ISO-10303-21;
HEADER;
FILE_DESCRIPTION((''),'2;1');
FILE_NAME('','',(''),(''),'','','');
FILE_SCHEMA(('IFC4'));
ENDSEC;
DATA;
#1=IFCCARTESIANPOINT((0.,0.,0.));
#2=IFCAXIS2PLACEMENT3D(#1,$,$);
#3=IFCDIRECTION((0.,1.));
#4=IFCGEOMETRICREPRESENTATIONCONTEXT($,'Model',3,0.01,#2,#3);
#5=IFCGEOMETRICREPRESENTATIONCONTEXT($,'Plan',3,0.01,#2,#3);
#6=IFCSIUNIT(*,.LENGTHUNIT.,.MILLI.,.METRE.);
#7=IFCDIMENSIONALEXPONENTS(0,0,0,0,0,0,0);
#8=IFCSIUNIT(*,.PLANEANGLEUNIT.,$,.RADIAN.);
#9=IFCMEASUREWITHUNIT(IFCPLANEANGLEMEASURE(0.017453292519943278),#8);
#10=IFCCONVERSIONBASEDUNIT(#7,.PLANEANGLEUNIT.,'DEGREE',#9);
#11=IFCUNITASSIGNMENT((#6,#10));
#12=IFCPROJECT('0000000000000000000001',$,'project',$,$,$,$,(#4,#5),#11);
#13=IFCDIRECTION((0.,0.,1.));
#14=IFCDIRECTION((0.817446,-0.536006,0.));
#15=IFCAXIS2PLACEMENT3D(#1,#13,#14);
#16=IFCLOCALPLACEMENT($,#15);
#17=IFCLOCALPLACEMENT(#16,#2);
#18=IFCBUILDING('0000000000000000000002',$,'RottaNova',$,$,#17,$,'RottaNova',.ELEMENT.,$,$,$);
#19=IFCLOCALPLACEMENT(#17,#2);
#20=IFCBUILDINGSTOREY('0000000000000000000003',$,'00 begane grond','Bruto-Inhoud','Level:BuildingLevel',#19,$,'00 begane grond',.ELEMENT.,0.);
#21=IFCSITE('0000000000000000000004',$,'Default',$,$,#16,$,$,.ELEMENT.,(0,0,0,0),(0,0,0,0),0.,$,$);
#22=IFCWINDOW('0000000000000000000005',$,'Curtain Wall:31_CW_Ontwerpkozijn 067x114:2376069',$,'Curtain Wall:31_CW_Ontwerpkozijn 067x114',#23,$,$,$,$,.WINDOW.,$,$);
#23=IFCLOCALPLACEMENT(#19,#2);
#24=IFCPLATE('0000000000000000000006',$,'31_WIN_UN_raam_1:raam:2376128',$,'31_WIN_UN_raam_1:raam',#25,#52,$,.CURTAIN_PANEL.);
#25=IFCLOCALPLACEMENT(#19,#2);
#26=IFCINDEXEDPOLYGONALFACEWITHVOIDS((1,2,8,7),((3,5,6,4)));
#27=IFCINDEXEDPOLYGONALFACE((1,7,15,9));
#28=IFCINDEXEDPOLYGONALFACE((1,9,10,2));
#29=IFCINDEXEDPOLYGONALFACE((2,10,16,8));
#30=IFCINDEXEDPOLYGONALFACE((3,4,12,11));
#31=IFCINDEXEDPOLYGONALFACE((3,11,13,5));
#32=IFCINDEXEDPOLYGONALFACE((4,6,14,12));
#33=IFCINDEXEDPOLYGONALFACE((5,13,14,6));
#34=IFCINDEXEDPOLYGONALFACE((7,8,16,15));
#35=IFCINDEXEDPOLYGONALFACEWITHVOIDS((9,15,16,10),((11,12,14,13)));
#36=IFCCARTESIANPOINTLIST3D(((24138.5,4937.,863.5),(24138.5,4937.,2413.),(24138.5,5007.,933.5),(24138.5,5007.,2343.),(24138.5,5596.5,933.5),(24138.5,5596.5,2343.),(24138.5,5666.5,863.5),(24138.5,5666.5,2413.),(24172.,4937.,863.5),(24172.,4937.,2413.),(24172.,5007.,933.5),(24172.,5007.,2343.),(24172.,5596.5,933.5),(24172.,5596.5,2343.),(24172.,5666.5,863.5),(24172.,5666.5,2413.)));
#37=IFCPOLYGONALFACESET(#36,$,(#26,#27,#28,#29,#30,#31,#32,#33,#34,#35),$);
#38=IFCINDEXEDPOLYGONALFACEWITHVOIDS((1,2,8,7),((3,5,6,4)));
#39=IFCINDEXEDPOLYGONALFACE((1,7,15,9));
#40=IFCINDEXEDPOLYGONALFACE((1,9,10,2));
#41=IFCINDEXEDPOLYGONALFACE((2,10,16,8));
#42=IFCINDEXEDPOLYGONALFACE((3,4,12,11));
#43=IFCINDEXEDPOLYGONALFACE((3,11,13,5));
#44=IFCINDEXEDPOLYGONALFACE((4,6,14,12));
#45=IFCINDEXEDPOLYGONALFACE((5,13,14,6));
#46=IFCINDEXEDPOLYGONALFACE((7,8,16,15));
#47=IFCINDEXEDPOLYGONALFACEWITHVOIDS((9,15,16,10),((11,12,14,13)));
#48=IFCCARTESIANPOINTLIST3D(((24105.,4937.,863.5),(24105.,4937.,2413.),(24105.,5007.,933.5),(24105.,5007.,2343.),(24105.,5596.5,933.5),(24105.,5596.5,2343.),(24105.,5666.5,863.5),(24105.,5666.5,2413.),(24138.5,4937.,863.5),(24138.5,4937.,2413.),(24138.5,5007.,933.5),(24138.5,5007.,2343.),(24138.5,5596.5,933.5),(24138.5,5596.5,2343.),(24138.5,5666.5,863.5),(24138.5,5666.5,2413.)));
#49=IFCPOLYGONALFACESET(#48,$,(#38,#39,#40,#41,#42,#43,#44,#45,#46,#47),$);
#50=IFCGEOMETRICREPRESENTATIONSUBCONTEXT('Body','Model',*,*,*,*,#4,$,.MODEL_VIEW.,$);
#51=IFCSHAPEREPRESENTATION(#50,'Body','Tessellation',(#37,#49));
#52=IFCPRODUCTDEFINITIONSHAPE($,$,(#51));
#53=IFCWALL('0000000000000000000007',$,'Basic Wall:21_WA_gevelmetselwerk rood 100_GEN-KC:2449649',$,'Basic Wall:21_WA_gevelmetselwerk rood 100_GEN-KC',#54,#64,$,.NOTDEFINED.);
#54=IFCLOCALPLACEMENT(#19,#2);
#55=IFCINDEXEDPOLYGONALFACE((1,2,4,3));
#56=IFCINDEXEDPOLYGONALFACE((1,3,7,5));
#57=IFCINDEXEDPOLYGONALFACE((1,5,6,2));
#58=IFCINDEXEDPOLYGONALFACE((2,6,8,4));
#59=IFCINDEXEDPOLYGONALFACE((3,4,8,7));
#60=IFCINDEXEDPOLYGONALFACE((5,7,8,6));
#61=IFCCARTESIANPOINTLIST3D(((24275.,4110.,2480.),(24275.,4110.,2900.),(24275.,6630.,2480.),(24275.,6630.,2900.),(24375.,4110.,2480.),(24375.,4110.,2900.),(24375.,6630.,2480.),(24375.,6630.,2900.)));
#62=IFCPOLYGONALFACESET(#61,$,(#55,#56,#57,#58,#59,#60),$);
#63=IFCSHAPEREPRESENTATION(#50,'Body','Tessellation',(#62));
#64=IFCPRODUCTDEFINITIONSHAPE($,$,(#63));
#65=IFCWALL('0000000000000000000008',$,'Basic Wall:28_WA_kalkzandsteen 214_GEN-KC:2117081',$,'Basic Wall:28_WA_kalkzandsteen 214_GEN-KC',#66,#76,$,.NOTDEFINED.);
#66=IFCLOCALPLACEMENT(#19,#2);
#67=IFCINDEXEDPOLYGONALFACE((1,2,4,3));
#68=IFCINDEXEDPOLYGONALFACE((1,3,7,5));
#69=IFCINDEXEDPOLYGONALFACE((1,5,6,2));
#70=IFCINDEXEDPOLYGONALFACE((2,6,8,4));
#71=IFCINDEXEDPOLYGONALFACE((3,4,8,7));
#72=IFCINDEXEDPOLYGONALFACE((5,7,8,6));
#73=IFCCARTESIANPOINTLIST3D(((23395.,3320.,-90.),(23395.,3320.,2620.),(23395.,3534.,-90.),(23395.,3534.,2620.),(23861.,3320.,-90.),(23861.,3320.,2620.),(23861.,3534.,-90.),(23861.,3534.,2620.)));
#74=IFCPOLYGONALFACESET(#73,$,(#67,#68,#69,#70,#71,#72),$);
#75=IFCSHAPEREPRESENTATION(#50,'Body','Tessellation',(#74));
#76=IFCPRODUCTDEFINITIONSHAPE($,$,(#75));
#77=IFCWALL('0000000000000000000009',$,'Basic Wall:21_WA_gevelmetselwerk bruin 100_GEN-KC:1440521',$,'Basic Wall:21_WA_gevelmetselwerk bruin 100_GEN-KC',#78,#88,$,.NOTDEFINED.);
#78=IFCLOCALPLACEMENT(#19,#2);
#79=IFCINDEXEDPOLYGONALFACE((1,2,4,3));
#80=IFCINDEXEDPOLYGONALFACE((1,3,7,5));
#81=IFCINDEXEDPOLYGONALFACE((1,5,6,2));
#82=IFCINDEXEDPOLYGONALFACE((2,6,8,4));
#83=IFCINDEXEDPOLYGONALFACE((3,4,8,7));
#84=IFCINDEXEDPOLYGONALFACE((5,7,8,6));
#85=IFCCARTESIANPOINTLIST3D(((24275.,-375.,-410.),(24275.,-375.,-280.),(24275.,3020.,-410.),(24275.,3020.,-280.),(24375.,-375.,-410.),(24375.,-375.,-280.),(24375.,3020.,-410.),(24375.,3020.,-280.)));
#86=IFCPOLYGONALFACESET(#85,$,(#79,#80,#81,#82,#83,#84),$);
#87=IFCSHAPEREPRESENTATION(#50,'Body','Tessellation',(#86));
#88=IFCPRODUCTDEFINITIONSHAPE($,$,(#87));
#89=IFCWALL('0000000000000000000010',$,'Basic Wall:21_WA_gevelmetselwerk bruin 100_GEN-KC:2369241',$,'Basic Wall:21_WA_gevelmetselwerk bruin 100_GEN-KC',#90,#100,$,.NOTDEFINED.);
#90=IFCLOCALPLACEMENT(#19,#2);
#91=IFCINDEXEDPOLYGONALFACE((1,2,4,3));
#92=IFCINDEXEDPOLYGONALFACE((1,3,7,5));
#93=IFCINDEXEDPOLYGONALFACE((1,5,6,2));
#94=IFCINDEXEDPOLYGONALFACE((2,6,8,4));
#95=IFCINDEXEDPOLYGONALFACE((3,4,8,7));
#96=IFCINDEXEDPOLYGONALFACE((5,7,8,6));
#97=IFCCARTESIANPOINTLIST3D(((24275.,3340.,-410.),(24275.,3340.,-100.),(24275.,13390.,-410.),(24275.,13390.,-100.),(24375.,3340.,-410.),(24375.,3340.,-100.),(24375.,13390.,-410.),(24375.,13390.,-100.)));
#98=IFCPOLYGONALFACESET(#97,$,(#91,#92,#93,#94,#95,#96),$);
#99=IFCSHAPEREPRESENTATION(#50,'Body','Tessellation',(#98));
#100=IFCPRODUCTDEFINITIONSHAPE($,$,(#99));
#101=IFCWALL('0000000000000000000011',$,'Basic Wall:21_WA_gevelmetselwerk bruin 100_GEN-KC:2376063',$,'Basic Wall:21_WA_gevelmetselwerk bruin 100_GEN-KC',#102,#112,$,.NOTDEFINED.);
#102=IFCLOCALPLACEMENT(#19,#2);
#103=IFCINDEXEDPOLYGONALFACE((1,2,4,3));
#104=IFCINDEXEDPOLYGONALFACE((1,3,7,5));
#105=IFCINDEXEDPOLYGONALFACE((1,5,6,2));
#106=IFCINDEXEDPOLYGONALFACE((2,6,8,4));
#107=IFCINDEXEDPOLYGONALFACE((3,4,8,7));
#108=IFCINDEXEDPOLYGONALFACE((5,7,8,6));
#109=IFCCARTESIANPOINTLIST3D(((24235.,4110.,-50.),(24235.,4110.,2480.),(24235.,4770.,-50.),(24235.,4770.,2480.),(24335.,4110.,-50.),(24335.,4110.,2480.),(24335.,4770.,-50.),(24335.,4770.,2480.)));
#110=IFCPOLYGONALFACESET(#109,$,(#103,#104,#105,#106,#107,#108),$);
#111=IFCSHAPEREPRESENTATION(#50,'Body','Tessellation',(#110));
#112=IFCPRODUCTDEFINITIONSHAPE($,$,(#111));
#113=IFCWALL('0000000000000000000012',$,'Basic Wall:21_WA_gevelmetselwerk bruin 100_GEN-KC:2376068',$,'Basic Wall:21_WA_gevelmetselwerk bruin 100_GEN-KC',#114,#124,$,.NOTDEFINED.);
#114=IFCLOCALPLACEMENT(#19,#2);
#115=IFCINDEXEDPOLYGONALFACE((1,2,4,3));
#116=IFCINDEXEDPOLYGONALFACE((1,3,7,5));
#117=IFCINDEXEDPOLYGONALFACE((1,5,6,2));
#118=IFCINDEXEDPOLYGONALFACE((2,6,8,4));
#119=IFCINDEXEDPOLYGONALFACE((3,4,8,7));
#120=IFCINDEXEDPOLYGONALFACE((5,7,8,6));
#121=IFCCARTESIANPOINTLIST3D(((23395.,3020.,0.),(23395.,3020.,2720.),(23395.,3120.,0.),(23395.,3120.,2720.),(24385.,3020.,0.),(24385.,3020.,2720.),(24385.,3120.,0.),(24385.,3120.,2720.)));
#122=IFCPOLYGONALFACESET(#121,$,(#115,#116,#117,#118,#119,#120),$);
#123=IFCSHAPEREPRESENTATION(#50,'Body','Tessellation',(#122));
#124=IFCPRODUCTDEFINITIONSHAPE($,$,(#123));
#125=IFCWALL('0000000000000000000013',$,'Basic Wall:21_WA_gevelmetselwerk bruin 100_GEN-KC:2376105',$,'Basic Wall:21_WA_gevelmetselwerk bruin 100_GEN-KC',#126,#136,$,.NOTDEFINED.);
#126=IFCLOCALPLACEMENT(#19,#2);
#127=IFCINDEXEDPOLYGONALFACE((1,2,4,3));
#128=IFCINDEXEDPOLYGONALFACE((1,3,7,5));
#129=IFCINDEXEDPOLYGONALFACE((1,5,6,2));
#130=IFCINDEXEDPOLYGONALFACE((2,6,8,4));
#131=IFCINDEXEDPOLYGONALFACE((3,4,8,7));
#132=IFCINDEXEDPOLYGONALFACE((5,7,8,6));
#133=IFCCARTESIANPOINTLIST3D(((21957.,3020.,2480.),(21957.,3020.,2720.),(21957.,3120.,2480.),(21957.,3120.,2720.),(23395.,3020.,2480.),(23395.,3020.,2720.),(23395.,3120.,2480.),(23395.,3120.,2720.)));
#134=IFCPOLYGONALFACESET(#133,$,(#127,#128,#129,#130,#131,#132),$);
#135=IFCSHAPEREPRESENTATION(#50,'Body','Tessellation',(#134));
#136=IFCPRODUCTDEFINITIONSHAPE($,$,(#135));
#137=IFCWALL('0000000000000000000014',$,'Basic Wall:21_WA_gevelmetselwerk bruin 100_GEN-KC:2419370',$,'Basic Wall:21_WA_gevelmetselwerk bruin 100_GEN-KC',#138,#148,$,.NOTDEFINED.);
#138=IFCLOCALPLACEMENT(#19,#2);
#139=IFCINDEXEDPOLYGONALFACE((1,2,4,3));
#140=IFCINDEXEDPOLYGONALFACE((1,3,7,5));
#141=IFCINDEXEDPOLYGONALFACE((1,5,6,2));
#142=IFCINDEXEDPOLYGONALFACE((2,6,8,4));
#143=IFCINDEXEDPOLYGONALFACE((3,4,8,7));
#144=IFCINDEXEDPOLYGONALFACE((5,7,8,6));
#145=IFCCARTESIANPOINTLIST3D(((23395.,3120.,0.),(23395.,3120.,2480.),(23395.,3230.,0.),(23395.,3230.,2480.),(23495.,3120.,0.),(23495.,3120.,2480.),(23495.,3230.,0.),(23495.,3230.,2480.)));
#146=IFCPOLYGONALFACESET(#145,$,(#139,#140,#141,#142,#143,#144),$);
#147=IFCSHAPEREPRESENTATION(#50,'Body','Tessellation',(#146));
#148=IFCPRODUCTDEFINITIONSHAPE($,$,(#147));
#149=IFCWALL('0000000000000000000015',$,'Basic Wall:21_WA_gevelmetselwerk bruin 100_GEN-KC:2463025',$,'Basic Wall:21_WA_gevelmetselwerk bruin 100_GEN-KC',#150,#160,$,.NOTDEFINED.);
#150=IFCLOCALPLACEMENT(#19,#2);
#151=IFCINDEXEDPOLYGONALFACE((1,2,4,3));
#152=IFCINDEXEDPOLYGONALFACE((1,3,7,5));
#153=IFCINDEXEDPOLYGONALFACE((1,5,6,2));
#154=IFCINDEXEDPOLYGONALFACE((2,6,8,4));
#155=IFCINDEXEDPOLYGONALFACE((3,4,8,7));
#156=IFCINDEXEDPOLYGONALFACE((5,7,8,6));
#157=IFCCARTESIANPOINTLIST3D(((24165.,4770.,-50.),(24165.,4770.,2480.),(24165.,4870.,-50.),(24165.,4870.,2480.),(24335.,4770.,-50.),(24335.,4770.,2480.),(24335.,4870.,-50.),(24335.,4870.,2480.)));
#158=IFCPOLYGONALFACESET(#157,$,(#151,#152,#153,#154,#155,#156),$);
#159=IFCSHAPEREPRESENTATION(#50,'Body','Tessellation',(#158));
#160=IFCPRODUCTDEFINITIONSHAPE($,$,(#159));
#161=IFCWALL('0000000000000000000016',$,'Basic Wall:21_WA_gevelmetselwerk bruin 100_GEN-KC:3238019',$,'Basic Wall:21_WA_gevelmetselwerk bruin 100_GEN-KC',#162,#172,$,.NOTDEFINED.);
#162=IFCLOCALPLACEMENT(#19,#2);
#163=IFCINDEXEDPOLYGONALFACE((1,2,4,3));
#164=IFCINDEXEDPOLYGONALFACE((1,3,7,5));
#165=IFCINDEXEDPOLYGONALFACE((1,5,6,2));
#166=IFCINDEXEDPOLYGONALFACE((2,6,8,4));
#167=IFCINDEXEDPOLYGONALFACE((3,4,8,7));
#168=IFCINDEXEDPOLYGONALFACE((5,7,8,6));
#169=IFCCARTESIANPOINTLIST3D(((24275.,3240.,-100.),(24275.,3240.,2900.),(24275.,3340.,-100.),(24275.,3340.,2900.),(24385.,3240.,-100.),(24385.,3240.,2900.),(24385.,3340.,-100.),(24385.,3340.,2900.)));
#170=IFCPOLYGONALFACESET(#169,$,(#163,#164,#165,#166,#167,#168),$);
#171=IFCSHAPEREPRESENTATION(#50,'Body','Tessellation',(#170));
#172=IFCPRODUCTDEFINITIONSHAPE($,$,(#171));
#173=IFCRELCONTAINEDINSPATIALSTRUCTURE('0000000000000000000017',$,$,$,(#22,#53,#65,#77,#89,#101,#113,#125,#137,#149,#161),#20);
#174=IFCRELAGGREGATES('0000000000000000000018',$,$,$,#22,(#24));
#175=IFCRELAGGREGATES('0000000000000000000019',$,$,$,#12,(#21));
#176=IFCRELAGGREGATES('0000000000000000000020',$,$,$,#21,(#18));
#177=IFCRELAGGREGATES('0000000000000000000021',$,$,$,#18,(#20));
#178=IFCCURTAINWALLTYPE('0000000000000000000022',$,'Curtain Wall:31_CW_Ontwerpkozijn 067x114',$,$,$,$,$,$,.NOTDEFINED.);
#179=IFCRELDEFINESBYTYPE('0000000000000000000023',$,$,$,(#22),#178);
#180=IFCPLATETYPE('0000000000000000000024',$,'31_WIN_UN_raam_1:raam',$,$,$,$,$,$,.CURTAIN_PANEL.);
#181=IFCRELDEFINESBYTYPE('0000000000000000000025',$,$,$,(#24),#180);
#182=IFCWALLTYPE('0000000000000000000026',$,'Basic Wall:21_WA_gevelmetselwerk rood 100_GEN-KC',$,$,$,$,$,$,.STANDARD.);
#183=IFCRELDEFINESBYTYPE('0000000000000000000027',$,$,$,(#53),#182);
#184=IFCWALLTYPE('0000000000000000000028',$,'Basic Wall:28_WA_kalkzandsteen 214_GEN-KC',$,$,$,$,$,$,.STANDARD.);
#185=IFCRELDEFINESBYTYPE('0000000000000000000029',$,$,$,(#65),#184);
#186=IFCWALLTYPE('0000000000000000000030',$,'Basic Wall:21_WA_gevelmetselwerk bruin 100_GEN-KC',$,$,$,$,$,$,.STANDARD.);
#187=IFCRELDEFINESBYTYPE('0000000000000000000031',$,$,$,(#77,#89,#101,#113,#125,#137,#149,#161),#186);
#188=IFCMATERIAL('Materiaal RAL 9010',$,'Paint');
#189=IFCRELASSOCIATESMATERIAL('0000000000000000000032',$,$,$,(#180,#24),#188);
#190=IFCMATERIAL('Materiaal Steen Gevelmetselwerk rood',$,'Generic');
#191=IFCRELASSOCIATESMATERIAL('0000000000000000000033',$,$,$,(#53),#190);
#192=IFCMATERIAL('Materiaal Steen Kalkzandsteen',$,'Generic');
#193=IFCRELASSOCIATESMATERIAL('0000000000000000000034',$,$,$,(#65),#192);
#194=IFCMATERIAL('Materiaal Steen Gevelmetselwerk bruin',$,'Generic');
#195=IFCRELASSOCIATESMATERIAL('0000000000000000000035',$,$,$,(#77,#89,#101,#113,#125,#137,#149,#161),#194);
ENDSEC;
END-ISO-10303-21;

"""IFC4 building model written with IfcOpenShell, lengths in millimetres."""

from ifc_helpers import new_model, entity, si_unit, converted_unit, direction, frame, origin, place, context, subcontext, project, spatial, indexed_curve, outline, extrude, source, transform, mapped, material, type_object, type_shapes, element, aggregate, save


model = new_model("IFC4")

# Units and contexts
model_context = context("Model", 3, precision=0.01, world=origin(), true_north=direction((0.0, 1.0)))
plan_context = context("Plan", 3, precision=0.01, world=origin(), true_north=direction((0.0, 1.0)))
body_context = subcontext(model_context, "Body", "Model", "MODEL_VIEW")
ifc_project = project(units=[si_unit("LENGTHUNIT", "METRE", prefix="MILLI"), converted_unit("PLANEANGLEUNIT", "DEGREE", entity("IfcPlaneAngleMeasure", 0.017453292519943278), si_unit("PLANEANGLEUNIT", "RADIAN"), dimensions=[0, 0, 0, 0, 0, 0, 0])], contexts=[model_context, plan_context])

# Site, building, storey
site_placement = place(None, frame((0.0, 0.0, 0.0), z_axis=(0.0, 0.0, 1.0), x_axis=(0.817446, -0.536006, 0.0)))
site = spatial("IfcSite", under=ifc_project, at=site_placement, Name="Default", CompositionType="ELEMENT", RefLatitude=(0, 0, 0, 0), RefLongitude=(0, 0, 0, 0), RefElevation=0.0)
building_placement = place(site_placement, origin())
building = spatial("IfcBuilding", under=site, at=building_placement, Name="RottaNova", LongName="RottaNova", CompositionType="ELEMENT")
storey_placement = place(building_placement, origin())
storey = spatial("IfcBuildingStorey", under=building, at=storey_placement, Name="00 begane grond", Description="Bruto-Inhoud", ObjectType="Level:BuildingLevel", LongName="00 begane grond", CompositionType="ELEMENT", Elevation=0.0)

# Window
curtain_wall_type = type_object("IfcCurtainWallType", Name="Curtain Wall:31_CW_Ontwerpkozijn 067x114", PredefinedType="NOTDEFINED")
window_1_placement = place(storey_placement, origin())
window_1 = element("IfcWindow", 1, at=window_1_placement, inside=storey, type_object=curtain_wall_type, Name="Curtain Wall:31_CW_Ontwerpkozijn 067x114:2376069", ObjectType="Curtain Wall:31_CW_Ontwerpkozijn 067x114", PredefinedType="WINDOW")

# Plate
ifc_material_1 = material(Name="Materiaal RAL 9010", Category="Paint")
plate_type_1 = type_object("IfcPlateType", Name="31_WIN_UN_raam_1:raam", PredefinedType="CURTAIN_PANEL", material=ifc_material_1)
shared_shape_1 = source(origin(), body_context, "Body", "SweptSolid", [
    extrude(outline(indexed_curve([(-364.7, -774.7), (364.7, -774.7), (364.7, 774.7), (-364.7, 774.7), (-364.7, -774.7)], self_intersect=False), holes=[indexed_curve([(-294.7, 704.7), (294.7, 704.7), (294.7, -704.8), (-294.7, -704.8), (-294.7, 704.7)], self_intersect=False)]), frame((0.0, 58.5, 774.8), z_axis=(0.0, 1.0, 0.0), x_axis=(1.0, 0.0, 0.0)), (0.0, 0.0, 1.0), 33.5),
    extrude(outline(indexed_curve([(-364.7, -774.7), (364.7, -774.7), (364.7, 774.7), (-364.7, 774.7), (-364.7, -774.7)], self_intersect=False), holes=[indexed_curve([(-294.7, 704.7), (294.7, 704.7), (294.7, -704.8), (-294.7, -704.8), (-294.7, 704.7)], self_intersect=False)]), frame((0.0, 25.0, 774.8), z_axis=(0.0, 1.0, 0.0), x_axis=(1.0, 0.0, 0.0)), (0.0, 0.0, 1.0), 33.5),
])
type_shapes(plate_type_1, [shared_shape_1])
plate_1_placement = place(window_1_placement, frame((24080.0, 5301.7, 863.5), z_axis=(0.0, 0.0, 1.0), x_axis=(0.0, -1.0, 0.0)))
plate_1 = element("IfcPlate", 2, at=plate_1_placement, type_object=plate_type_1, material=ifc_material_1, Name="31_WIN_UN_raam_1:raam:2376128", ObjectType="31_WIN_UN_raam_1:raam", PredefinedType="CURTAIN_PANEL", context=body_context, shape_type="MappedRepresentation", body=[
    mapped(shared_shape_1, transform((0.0, 0.0, 0.0), scale=1.0)),
])
aggregate(window_1, [plate_1])

# Walls
ifc_material_2 = material(Name="Materiaal Steen Gevelmetselwerk rood", Category="Generic")
wall_type_1 = type_object("IfcWallType", Name="Basic Wall:21_WA_gevelmetselwerk rood 100_GEN-KC", PredefinedType="STANDARD")
wall_1_placement = place(storey_placement, frame((24325.0, 4110.0, 2480.0), z_axis=(0.0, 0.0, 1.0), x_axis=(0.0, 1.0, 0.0)))
element("IfcWall", 3, at=wall_1_placement, inside=storey, type_object=wall_type_1, material=ifc_material_2, Name="Basic Wall:21_WA_gevelmetselwerk rood 100_GEN-KC:2449649", ObjectType="Basic Wall:21_WA_gevelmetselwerk rood 100_GEN-KC", PredefinedType="NOTDEFINED", context=body_context, shape_type="SweptSolid", body=[
    extrude(outline(indexed_curve([(2520.0, 50.0), (0.0, 50.0), (0.0, -50.0), (2520.0, -50.0), (2520.0, 50.0)], self_intersect=False)), origin(), (0.0, 0.0, 1.0), 420.0),
])
ifc_material_3 = material(Name="Materiaal Steen Kalkzandsteen", Category="Generic")
wall_type_2 = type_object("IfcWallType", Name="Basic Wall:28_WA_kalkzandsteen 214_GEN-KC", PredefinedType="STANDARD")
wall_2_placement = place(storey_placement, frame((23861.0, 3427.0, -90.0), z_axis=(0.0, 0.0, 1.0), x_axis=(-1.0, 0.0, 0.0)))
element("IfcWall", 4, at=wall_2_placement, inside=storey, type_object=wall_type_2, material=ifc_material_3, Name="Basic Wall:28_WA_kalkzandsteen 214_GEN-KC:2117081", ObjectType="Basic Wall:28_WA_kalkzandsteen 214_GEN-KC", PredefinedType="NOTDEFINED", context=body_context, shape_type="SweptSolid", body=[
    extrude(outline(indexed_curve([(466.0, 107.0), (0.0, 107.0), (0.0, -107.0), (466.0, -107.0), (466.0, 107.0)], self_intersect=False)), origin(), (0.0, 0.0, 1.0), 2710.0),
])
ifc_material_4 = material(Name="Materiaal Steen Gevelmetselwerk bruin", Category="Generic")
wall_type_3 = type_object("IfcWallType", Name="Basic Wall:21_WA_gevelmetselwerk bruin 100_GEN-KC", PredefinedType="STANDARD")
wall_3_placement = place(storey_placement, frame((24325.0, 3020.0, -410.0), z_axis=(0.0, 0.0, 1.0), x_axis=(0.0, -1.0, 0.0)))
element("IfcWall", 5, at=wall_3_placement, inside=storey, type_object=wall_type_3, material=ifc_material_4, Name="Basic Wall:21_WA_gevelmetselwerk bruin 100_GEN-KC:1440521", ObjectType="Basic Wall:21_WA_gevelmetselwerk bruin 100_GEN-KC", PredefinedType="NOTDEFINED", context=body_context, shape_type="SweptSolid", body=[
    extrude(outline(indexed_curve([(3395.0, 50.0), (0.0, 50.0), (0.0, -50.0), (3395.0, -50.0), (3395.0, 50.0)], self_intersect=False)), origin(), (0.0, 0.0, 1.0), 130.0),
])
wall_4_placement = place(storey_placement, frame((24325.0, 3340.0, -410.0), z_axis=(0.0, 0.0, 1.0), x_axis=(0.0, 1.0, 0.0)))
element("IfcWall", 6, at=wall_4_placement, inside=storey, type_object=wall_type_3, material=ifc_material_4, Name="Basic Wall:21_WA_gevelmetselwerk bruin 100_GEN-KC:2369241", ObjectType="Basic Wall:21_WA_gevelmetselwerk bruin 100_GEN-KC", PredefinedType="NOTDEFINED", context=body_context, shape_type="SweptSolid", body=[
    extrude(outline(indexed_curve([(10050.0, 50.0), (0.0, 50.0), (0.0, -50.0), (10050.0, -50.0), (10050.0, 50.0)], self_intersect=False)), origin(), (0.0, 0.0, 1.0), 310.0),
])
wall_5_placement = place(storey_placement, frame((24285.0, 4110.0, -50.0), z_axis=(0.0, 0.0, 1.0), x_axis=(0.0, 1.0, 0.0)))
element("IfcWall", 7, at=wall_5_placement, inside=storey, type_object=wall_type_3, material=ifc_material_4, Name="Basic Wall:21_WA_gevelmetselwerk bruin 100_GEN-KC:2376063", ObjectType="Basic Wall:21_WA_gevelmetselwerk bruin 100_GEN-KC", PredefinedType="NOTDEFINED", context=body_context, shape_type="SweptSolid", body=[
    extrude(outline(indexed_curve([(660.0, 50.0), (0.0, 50.0), (0.0, -50.0), (660.0, -50.0), (660.0, 50.0)], self_intersect=False)), origin(), (0.0, 0.0, 1.0), 2530.0),
])
wall_6_placement = place(storey_placement, frame((23395.0, 3070.0, 0.0)))
element("IfcWall", 8, at=wall_6_placement, inside=storey, type_object=wall_type_3, material=ifc_material_4, Name="Basic Wall:21_WA_gevelmetselwerk bruin 100_GEN-KC:2376068", ObjectType="Basic Wall:21_WA_gevelmetselwerk bruin 100_GEN-KC", PredefinedType="NOTDEFINED", context=body_context, shape_type="SweptSolid", body=[
    extrude(outline(indexed_curve([(990.0, 50.0), (0.0, 50.0), (0.0, -50.0), (990.0, -50.0), (990.0, 50.0)], self_intersect=False)), origin(), (0.0, 0.0, 1.0), 2720.0),
])
wall_7_placement = place(storey_placement, frame((23395.0, 3070.0, 2480.0), z_axis=(0.0, 0.0, 1.0), x_axis=(-1.0, 0.0, 0.0)))
element("IfcWall", 9, at=wall_7_placement, inside=storey, type_object=wall_type_3, material=ifc_material_4, Name="Basic Wall:21_WA_gevelmetselwerk bruin 100_GEN-KC:2376105", ObjectType="Basic Wall:21_WA_gevelmetselwerk bruin 100_GEN-KC", PredefinedType="NOTDEFINED", context=body_context, shape_type="SweptSolid", body=[
    extrude(outline(indexed_curve([(1438.0, 50.0), (0.0, 50.0), (0.0, -50.0), (1438.0, -50.0), (1438.0, 50.0)], self_intersect=False)), origin(), (0.0, 0.0, 1.0), 240.0),
])
wall_8_placement = place(storey_placement, frame((23445.0, 3230.0, 0.0), z_axis=(0.0, 0.0, 1.0), x_axis=(0.0, -1.0, 0.0)))
element("IfcWall", 10, at=wall_8_placement, inside=storey, type_object=wall_type_3, material=ifc_material_4, Name="Basic Wall:21_WA_gevelmetselwerk bruin 100_GEN-KC:2419370", ObjectType="Basic Wall:21_WA_gevelmetselwerk bruin 100_GEN-KC", PredefinedType="NOTDEFINED", context=body_context, shape_type="SweptSolid", body=[
    extrude(outline(indexed_curve([(110.0, 50.0), (0.0, 50.0), (0.0, -50.0), (110.0, -50.0), (110.0, 50.0)], self_intersect=False)), origin(), (0.0, 0.0, 1.0), 2480.0),
])
wall_9_placement = place(storey_placement, frame((24335.0, 4820.0, -50.0), z_axis=(0.0, 0.0, 1.0), x_axis=(-1.0, 0.0, 0.0)))
element("IfcWall", 11, at=wall_9_placement, inside=storey, type_object=wall_type_3, material=ifc_material_4, Name="Basic Wall:21_WA_gevelmetselwerk bruin 100_GEN-KC:2463025", ObjectType="Basic Wall:21_WA_gevelmetselwerk bruin 100_GEN-KC", PredefinedType="NOTDEFINED", context=body_context, shape_type="SweptSolid", body=[
    extrude(outline(indexed_curve([(170.0, 50.0), (0.0, 50.0), (0.0, -50.0), (170.0, -50.0), (170.0, 50.0)], self_intersect=False)), origin(), (0.0, 0.0, 1.0), 2530.0),
])
wall_10_placement = place(storey_placement, frame((24385.0, 3290.0, -100.0), z_axis=(0.0, 0.0, 1.0), x_axis=(-1.0, 0.0, 0.0)))
element("IfcWall", 12, at=wall_10_placement, inside=storey, type_object=wall_type_3, material=ifc_material_4, Name="Basic Wall:21_WA_gevelmetselwerk bruin 100_GEN-KC:3238019", ObjectType="Basic Wall:21_WA_gevelmetselwerk bruin 100_GEN-KC", PredefinedType="NOTDEFINED", context=body_context, shape_type="SweptSolid", body=[
    extrude(outline(indexed_curve([(110.0, 50.0), (0.0, 50.0), (0.0, -50.0), (110.0, -50.0), (110.0, 50.0)], self_intersect=False)), origin(), (0.0, 0.0, 1.0), 3000.0),
])

save(model, "model.ifc")
